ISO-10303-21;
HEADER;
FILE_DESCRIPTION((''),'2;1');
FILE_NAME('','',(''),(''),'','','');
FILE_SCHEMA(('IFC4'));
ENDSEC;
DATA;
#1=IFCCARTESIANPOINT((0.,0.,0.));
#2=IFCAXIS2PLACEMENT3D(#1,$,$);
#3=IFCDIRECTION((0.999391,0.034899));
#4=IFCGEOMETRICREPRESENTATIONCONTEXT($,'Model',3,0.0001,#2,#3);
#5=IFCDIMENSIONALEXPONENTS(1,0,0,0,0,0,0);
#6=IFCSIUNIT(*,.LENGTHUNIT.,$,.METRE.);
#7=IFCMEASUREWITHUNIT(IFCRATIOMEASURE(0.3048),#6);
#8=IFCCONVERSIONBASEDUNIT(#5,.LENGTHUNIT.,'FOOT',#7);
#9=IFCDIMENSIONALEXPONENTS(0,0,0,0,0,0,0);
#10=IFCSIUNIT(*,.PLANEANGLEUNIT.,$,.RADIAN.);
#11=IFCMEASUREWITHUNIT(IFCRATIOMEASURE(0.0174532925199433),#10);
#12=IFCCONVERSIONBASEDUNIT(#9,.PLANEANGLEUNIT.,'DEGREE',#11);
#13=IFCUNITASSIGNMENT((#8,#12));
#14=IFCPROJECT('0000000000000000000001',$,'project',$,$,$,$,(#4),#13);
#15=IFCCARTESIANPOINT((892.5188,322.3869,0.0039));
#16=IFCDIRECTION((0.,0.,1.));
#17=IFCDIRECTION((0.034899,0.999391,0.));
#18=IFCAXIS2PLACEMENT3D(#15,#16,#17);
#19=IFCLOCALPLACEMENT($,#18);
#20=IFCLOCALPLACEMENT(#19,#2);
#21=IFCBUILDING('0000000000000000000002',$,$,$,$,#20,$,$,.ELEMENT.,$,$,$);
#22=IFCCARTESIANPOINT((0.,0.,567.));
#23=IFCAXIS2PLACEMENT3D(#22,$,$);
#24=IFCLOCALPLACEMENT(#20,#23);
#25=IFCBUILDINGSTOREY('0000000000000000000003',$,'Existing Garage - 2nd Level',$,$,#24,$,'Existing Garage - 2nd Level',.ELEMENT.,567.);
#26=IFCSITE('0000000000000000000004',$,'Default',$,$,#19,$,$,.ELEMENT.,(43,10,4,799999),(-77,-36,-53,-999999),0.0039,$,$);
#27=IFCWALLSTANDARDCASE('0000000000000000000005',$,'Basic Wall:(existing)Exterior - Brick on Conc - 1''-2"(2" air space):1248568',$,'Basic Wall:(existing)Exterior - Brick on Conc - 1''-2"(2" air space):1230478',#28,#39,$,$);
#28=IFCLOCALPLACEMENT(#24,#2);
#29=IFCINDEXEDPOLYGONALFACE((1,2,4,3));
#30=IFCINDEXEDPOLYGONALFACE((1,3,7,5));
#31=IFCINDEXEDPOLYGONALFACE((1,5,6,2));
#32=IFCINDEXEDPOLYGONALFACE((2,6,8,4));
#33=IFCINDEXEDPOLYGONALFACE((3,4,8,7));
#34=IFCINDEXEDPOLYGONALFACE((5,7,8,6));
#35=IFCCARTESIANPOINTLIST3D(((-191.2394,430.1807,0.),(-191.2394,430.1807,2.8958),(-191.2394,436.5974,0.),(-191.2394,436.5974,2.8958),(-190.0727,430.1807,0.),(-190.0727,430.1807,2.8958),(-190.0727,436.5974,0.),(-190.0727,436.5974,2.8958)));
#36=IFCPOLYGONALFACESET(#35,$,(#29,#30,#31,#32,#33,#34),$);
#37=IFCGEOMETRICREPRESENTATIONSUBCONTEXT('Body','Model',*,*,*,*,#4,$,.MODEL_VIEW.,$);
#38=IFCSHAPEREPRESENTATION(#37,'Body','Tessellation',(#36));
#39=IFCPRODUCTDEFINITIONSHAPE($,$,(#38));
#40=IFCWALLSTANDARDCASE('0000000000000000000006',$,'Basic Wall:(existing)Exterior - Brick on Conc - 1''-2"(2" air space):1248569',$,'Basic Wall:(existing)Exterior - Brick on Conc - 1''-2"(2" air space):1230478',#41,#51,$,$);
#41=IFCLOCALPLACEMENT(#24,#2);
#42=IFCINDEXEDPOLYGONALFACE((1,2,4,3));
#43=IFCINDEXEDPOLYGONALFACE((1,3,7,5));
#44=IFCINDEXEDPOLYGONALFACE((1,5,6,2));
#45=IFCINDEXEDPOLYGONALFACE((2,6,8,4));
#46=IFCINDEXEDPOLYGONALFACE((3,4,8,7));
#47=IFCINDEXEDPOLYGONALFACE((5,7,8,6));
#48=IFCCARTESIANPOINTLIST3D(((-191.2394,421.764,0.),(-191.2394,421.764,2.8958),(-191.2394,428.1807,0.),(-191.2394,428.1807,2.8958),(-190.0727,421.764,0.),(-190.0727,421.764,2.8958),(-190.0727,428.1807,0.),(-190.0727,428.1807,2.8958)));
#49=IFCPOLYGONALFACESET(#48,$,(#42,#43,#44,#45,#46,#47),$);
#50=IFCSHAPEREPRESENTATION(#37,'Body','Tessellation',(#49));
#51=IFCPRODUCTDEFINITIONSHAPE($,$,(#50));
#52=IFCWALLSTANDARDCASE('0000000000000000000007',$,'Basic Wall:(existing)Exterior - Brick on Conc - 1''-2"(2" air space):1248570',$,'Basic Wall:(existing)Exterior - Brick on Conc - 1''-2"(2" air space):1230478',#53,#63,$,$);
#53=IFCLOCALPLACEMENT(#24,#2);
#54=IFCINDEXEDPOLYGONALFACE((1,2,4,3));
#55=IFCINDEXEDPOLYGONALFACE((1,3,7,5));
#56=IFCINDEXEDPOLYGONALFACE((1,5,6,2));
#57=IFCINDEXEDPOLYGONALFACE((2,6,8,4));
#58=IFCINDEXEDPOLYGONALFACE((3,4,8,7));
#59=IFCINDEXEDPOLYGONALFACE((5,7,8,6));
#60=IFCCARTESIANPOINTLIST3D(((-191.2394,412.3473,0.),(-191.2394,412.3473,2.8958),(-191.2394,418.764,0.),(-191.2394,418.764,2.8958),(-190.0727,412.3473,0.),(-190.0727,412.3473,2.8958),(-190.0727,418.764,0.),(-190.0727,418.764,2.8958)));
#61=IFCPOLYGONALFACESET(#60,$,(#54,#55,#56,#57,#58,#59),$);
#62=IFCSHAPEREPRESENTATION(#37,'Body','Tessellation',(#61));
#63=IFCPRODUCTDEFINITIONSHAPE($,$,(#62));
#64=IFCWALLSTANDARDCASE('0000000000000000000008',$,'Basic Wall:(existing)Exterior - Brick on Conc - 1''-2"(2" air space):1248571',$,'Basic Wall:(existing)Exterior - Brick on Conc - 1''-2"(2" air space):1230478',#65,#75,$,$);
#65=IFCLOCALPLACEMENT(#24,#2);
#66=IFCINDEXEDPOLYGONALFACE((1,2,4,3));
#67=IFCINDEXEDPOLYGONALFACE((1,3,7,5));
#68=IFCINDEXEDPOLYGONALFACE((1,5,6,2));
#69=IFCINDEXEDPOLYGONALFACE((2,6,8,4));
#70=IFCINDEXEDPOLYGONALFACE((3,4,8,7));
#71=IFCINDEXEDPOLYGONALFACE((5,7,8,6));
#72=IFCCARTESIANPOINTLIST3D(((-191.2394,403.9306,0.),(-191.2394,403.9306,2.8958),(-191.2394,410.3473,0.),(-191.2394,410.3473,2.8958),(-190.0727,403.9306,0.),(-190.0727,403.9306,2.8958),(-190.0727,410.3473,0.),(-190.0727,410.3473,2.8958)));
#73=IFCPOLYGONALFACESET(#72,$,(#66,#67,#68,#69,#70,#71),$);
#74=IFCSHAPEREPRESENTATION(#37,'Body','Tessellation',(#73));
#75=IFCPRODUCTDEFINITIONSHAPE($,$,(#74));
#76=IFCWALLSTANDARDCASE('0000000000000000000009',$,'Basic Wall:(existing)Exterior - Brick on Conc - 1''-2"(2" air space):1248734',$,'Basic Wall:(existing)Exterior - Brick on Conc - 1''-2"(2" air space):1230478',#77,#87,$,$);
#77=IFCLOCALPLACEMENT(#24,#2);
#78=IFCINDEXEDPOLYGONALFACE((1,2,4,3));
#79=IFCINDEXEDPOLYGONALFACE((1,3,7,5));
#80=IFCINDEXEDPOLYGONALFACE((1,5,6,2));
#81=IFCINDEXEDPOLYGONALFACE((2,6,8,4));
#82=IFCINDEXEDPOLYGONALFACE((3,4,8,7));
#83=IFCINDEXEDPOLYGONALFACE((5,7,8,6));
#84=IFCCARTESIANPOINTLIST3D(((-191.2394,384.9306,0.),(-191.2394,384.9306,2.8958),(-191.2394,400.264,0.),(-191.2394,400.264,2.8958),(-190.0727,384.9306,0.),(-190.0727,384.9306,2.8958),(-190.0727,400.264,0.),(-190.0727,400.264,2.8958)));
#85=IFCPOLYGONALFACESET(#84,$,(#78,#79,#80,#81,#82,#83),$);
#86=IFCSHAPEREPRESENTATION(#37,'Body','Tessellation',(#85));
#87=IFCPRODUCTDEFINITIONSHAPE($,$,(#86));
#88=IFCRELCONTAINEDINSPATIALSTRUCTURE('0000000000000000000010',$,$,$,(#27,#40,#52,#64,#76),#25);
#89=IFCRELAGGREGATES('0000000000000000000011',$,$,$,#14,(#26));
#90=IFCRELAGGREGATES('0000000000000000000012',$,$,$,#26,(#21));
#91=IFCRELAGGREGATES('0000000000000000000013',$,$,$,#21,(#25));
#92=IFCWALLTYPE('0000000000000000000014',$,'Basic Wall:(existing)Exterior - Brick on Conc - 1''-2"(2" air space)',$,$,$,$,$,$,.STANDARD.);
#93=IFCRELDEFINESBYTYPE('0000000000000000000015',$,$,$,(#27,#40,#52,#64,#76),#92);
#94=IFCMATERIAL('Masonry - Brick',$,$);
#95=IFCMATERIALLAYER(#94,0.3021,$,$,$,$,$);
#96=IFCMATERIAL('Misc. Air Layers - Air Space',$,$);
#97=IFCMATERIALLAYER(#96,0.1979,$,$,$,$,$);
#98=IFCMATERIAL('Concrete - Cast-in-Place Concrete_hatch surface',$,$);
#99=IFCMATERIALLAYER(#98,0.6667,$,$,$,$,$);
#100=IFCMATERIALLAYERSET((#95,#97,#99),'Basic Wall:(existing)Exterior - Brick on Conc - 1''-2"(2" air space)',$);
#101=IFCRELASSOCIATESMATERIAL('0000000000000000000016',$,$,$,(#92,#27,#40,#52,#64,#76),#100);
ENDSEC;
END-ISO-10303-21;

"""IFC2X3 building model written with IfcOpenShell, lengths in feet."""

from ifc_helpers import new_model, entity, si_unit, converted_unit, direction, frame, frame_2d, origin, place, context, subcontext, project, spatial, rectangle, extrude, material, layer, layer_set, layer_usage, type_object, element, save


model = new_model("IFC2X3")

# Units and contexts
model_context = context("Model", 3, precision=0.0001, world=origin(), true_north=direction((0.999391, 0.034899)))
body_context = subcontext(model_context, "Body", "Model", "MODEL_VIEW")
ifc_project = project(units=[converted_unit("LENGTHUNIT", "FOOT", entity("IfcRatioMeasure", 0.3048), si_unit("LENGTHUNIT", "METRE"), dimensions=[1, 0, 0, 0, 0, 0, 0]), converted_unit("PLANEANGLEUNIT", "DEGREE", entity("IfcRatioMeasure", 0.0174532925199433), si_unit("PLANEANGLEUNIT", "RADIAN"), dimensions=[0, 0, 0, 0, 0, 0, 0])], contexts=[model_context])

# Site, building, storey
site_placement = place(None, frame((892.5188, 322.3869, 0.0039), z_axis=(0.0, 0.0, 1.0), x_axis=(0.034899, 0.999391, 0.0)))
site = spatial("IfcSite", under=ifc_project, at=site_placement, Name="Default", CompositionType="ELEMENT", RefLatitude=(43, 10, 4, 799999), RefLongitude=(-77, -36, -53, -999999), RefElevation=0.0039)
building_placement = place(site_placement, origin())
building = spatial("IfcBuilding", under=site, at=building_placement, CompositionType="ELEMENT")
storey_placement = place(building_placement, frame((0.0, 0.0, 567.0)))
storey = spatial("IfcBuildingStorey", under=building, at=storey_placement, Name="Existing Garage - 2nd Level", LongName="Existing Garage - 2nd Level", CompositionType="ELEMENT", Elevation=567.0)

# Walls
ifc_material_1 = material(Name="Masonry - Brick")
ifc_layer_1 = layer(ifc_material_1, 0.3021)
ifc_material_2 = material(Name="Misc. Air Layers - Air Space")
ifc_layer_2 = layer(ifc_material_2, 0.1979)
ifc_material_3 = material(Name="Concrete - Cast-in-Place Concrete_hatch surface")
ifc_layer_3 = layer(ifc_material_3, 0.6667)
ifc_layer_set = layer_set([ifc_layer_1, ifc_layer_2, ifc_layer_3], Name="Basic Wall:(existing)Exterior - Brick on Conc - 1'-2\"(2\" air space)")
ifc_layer_usage_1 = layer_usage(ifc_layer_set, "AXIS2", "POSITIVE", -0.5833)
wall_type = type_object("IfcWallType", Name="Basic Wall:(existing)Exterior - Brick on Conc - 1'-2\"(2\" air space)", PredefinedType="STANDARD", material=ifc_layer_set)
wall_1_placement = place(storey_placement, frame((-190.6561, 436.5974, 0.0), z_axis=(0.0, 0.0, 1.0), x_axis=(0.0, -1.0, 0.0)))
element("IfcWallStandardCase", 1, at=wall_1_placement, inside=storey, type_object=wall_type, material=ifc_layer_usage_1, Name="Basic Wall:(existing)Exterior - Brick on Conc - 1'-2\"(2\" air space):1248568", ObjectType="Basic Wall:(existing)Exterior - Brick on Conc - 1'-2\"(2\" air space):1230478", context=body_context, shape_type="SweptSolid", body=[
    extrude(rectangle(XDim=6.4167, YDim=1.1667, at=frame_2d((3.2084, 0.0), x_axis=(-1.0, 0.0))), origin(), (0.0, 0.0, 1.0), 2.8958),
])
ifc_layer_usage_2 = layer_usage(ifc_layer_set, "AXIS2", "POSITIVE", -0.5833)
wall_2_placement = place(storey_placement, frame((-190.6561, 428.1807, 0.0), z_axis=(0.0, 0.0, 1.0), x_axis=(0.0, -1.0, 0.0)))
element("IfcWallStandardCase", 2, at=wall_2_placement, inside=storey, type_object=wall_type, material=ifc_layer_usage_2, Name="Basic Wall:(existing)Exterior - Brick on Conc - 1'-2\"(2\" air space):1248569", ObjectType="Basic Wall:(existing)Exterior - Brick on Conc - 1'-2\"(2\" air space):1230478", context=body_context, shape_type="SweptSolid", body=[
    extrude(rectangle(XDim=6.4167, YDim=1.1667, at=frame_2d((3.2084, 0.0), x_axis=(-1.0, 0.0))), origin(), (0.0, 0.0, 1.0), 2.8958),
])
ifc_layer_usage_3 = layer_usage(ifc_layer_set, "AXIS2", "POSITIVE", -0.5833)
wall_3_placement = place(storey_placement, frame((-190.6561, 418.764, 0.0), z_axis=(0.0, 0.0, 1.0), x_axis=(0.0, -1.0, 0.0)))
element("IfcWallStandardCase", 3, at=wall_3_placement, inside=storey, type_object=wall_type, material=ifc_layer_usage_3, Name="Basic Wall:(existing)Exterior - Brick on Conc - 1'-2\"(2\" air space):1248570", ObjectType="Basic Wall:(existing)Exterior - Brick on Conc - 1'-2\"(2\" air space):1230478", context=body_context, shape_type="SweptSolid", body=[
    extrude(rectangle(XDim=6.4167, YDim=1.1667, at=frame_2d((3.2084, 0.0), x_axis=(-1.0, 0.0))), origin(), (0.0, 0.0, 1.0), 2.8958),
])
ifc_layer_usage_4 = layer_usage(ifc_layer_set, "AXIS2", "POSITIVE", -0.5833)
wall_4_placement = place(storey_placement, frame((-190.6561, 410.3473, 0.0), z_axis=(0.0, 0.0, 1.0), x_axis=(0.0, -1.0, 0.0)))
element("IfcWallStandardCase", 4, at=wall_4_placement, inside=storey, type_object=wall_type, material=ifc_layer_usage_4, Name="Basic Wall:(existing)Exterior - Brick on Conc - 1'-2\"(2\" air space):1248571", ObjectType="Basic Wall:(existing)Exterior - Brick on Conc - 1'-2\"(2\" air space):1230478", context=body_context, shape_type="SweptSolid", body=[
    extrude(rectangle(XDim=6.4167, YDim=1.1667, at=frame_2d((3.2084, 0.0), x_axis=(-1.0, 0.0))), origin(), (0.0, 0.0, 1.0), 2.8958),
])
ifc_layer_usage_5 = layer_usage(ifc_layer_set, "AXIS2", "POSITIVE", -0.5833)
wall_5_placement = place(storey_placement, frame((-190.6561, 400.264, 0.0), z_axis=(0.0, 0.0, 1.0), x_axis=(0.0, -1.0, 0.0)))
element("IfcWallStandardCase", 5, at=wall_5_placement, inside=storey, type_object=wall_type, material=ifc_layer_usage_5, Name="Basic Wall:(existing)Exterior - Brick on Conc - 1'-2\"(2\" air space):1248734", ObjectType="Basic Wall:(existing)Exterior - Brick on Conc - 1'-2\"(2\" air space):1230478", context=body_context, shape_type="SweptSolid", body=[
    extrude(rectangle(XDim=15.3333, YDim=1.1667, at=frame_2d((7.6667, 0.0), x_axis=(-1.0, 0.0))), origin(), (0.0, 0.0, 1.0), 2.8958),
])

save(model, "model.ifc")
